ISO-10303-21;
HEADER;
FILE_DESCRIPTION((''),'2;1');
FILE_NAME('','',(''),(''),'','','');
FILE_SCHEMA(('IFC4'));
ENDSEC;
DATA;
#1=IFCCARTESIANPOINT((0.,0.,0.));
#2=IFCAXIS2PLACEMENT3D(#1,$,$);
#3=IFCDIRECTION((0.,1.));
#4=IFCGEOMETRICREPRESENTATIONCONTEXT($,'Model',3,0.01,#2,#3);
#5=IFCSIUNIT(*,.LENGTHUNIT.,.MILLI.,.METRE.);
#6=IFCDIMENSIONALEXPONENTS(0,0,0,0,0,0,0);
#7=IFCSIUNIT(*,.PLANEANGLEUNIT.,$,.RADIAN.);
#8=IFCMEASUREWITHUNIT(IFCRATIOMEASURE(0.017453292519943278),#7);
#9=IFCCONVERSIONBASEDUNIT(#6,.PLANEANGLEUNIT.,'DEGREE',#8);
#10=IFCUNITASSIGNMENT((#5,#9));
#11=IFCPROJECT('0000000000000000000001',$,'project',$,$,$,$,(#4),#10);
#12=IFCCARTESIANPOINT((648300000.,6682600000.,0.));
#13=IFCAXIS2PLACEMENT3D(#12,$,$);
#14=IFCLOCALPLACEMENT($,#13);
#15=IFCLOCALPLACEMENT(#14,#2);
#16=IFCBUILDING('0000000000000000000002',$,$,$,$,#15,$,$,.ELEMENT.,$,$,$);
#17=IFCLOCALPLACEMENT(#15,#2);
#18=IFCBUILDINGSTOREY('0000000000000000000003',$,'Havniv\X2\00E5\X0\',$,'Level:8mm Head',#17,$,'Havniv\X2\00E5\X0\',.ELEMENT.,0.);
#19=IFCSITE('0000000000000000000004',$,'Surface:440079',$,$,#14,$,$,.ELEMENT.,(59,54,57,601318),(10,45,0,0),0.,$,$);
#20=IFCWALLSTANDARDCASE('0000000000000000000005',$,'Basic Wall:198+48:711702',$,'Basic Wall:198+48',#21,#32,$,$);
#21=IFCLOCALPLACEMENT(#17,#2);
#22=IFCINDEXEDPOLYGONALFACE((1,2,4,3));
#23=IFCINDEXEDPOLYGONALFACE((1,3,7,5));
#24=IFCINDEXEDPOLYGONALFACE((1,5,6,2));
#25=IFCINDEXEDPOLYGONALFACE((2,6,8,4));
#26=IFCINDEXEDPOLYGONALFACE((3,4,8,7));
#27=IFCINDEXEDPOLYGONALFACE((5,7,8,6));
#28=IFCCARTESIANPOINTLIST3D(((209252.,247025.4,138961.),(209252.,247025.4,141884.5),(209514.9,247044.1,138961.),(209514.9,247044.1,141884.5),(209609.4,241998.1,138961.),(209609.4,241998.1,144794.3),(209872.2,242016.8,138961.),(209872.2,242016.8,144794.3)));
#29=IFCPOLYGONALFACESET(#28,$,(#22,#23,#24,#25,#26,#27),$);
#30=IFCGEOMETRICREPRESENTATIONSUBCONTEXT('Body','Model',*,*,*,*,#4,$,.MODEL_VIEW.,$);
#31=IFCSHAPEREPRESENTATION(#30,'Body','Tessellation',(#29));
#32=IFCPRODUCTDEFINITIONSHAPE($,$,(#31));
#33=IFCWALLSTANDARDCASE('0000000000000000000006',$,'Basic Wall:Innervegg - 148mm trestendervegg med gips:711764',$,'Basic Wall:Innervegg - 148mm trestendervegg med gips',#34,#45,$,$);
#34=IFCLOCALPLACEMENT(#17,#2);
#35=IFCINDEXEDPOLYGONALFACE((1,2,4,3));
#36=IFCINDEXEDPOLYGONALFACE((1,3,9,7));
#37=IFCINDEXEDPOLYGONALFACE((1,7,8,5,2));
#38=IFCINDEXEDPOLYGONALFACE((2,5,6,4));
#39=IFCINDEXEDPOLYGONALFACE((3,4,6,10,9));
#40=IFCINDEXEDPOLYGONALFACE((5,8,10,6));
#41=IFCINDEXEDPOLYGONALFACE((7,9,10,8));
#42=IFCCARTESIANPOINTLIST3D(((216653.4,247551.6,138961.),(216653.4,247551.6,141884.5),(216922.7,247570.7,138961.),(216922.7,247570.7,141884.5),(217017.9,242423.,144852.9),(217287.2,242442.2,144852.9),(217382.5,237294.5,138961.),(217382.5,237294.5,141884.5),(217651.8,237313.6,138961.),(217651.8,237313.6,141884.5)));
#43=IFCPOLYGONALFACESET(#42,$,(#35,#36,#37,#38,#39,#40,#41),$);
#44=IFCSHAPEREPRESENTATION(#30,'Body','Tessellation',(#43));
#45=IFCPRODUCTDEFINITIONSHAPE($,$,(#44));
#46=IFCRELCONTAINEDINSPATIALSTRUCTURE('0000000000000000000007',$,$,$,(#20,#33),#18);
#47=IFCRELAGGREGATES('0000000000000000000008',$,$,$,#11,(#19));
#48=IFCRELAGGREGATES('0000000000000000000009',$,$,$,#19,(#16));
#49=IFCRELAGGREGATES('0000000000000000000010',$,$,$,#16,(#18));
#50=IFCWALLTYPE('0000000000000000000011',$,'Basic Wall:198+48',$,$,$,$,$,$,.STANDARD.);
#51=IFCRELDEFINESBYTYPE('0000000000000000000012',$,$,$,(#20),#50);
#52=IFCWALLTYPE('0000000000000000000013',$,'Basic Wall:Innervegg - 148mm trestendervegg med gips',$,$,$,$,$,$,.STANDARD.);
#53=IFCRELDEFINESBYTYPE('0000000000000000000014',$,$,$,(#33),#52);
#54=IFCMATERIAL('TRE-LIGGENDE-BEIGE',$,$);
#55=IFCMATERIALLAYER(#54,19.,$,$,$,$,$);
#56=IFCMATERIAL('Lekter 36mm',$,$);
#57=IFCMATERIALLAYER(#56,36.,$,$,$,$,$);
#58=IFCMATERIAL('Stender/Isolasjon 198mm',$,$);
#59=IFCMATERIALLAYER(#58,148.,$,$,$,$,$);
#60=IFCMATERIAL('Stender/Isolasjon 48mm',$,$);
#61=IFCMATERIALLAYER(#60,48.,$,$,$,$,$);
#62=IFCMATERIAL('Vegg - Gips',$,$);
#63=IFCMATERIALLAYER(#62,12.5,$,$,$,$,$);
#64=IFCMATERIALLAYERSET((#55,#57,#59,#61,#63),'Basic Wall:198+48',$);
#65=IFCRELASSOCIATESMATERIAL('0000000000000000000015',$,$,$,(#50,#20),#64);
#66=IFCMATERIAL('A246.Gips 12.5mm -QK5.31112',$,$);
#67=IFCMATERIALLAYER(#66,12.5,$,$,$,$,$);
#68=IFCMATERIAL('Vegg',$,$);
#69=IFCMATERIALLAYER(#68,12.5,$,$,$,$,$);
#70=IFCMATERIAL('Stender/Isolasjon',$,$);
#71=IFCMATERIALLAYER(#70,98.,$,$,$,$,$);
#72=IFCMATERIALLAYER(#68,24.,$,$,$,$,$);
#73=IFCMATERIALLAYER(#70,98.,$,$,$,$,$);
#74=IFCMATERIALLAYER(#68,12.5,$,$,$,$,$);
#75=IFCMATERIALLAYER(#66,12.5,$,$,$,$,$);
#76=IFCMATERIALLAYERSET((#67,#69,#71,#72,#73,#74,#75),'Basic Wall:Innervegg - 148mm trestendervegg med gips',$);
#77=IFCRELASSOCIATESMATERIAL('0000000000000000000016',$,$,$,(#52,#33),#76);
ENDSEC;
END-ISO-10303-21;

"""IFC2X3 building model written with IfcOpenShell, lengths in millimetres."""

from ifc_helpers import new_model, entity, si_unit, converted_unit, direction, frame, frame_2d, origin, place, context, subcontext, project, spatial, polyline, rectangle, extrude, clip, bounded_halfspace, material, layer, layer_set, layer_usage, type_object, element, save


model = new_model("IFC2X3")

# Units and contexts
model_context = context("Model", 3, precision=0.01, world=origin(), true_north=direction((0.0, 1.0)))
body_context = subcontext(model_context, "Body", "Model", "MODEL_VIEW")
ifc_project = project(units=[si_unit("LENGTHUNIT", "METRE", prefix="MILLI"), converted_unit("PLANEANGLEUNIT", "DEGREE", entity("IfcRatioMeasure", 0.017453292519943278), si_unit("PLANEANGLEUNIT", "RADIAN"), dimensions=[0, 0, 0, 0, 0, 0, 0])], contexts=[model_context])

# Site, building, storey
site_placement = place(None, frame((648300000.0, 6682600000.0, 0.0)))
site = spatial("IfcSite", under=ifc_project, at=site_placement, Name="Surface:440079", CompositionType="ELEMENT", RefLatitude=(59, 54, 57, 601318), RefLongitude=(10, 45, 0, 0), RefElevation=0.0)
building_placement = place(site_placement, origin())
building = spatial("IfcBuilding", under=site, at=building_placement, CompositionType="ELEMENT")
storey_placement = place(building_placement, origin())
storey = spatial("IfcBuildingStorey", under=building, at=storey_placement, Name="Havnivå", ObjectType="Level:8mm Head", LongName="Havnivå", CompositionType="ELEMENT", Elevation=0.0)

# Walls
ifc_material_1 = material(Name="TRE-LIGGENDE-BEIGE")
ifc_layer_1 = layer(ifc_material_1, 19.0)
ifc_material_2 = material(Name="Lekter 36mm")
ifc_layer_2 = layer(ifc_material_2, 36.0)
ifc_material_3 = material(Name="Stender/Isolasjon 198mm")
ifc_layer_3 = layer(ifc_material_3, 148.0)
ifc_material_4 = material(Name="Stender/Isolasjon 48mm")
ifc_layer_4 = layer(ifc_material_4, 48.0)
ifc_material_5 = material(Name="Vegg - Gips")
ifc_layer_5 = layer(ifc_material_5, 12.5)
ifc_layer_set_1 = layer_set([ifc_layer_1, ifc_layer_2, ifc_layer_3, ifc_layer_4, ifc_layer_5], Name="Basic Wall:198+48")
ifc_layer_usage_1 = layer_usage(ifc_layer_set_1, "AXIS2", "POSITIVE", -131.8)
wall_type_1 = type_object("IfcWallType", Name="Basic Wall:198+48", PredefinedType="STANDARD", material=ifc_layer_set_1)
wall_1_placement = place(storey_placement, frame((209383.4, 247034.8, 138961.0), z_axis=(0.0, 0.0, 1.0), x_axis=(0.070908, -0.997483, 0.0)))
element("IfcWallStandardCase", 1, at=wall_1_placement, inside=storey, type_object=wall_type_1, material=ifc_layer_usage_1, Name="Basic Wall:198+48:711702", ObjectType="Basic Wall:198+48", context=body_context, shape_type="Clipping", body=[
    clip(extrude(rectangle(XDim=5040.0, YDim=263.5, at=frame_2d((2520.0, 0.0), x_axis=(-1.0, 0.0))), origin(), (0.0, 0.0, 1.0), 5833.3), bounded_halfspace(frame((0.0, -131.8, 2923.5), z_axis=(-0.5, 0.0, 0.866025), x_axis=(0.0, -1.0, 0.0)), False, frame((0.0, -131.8, 2923.5)), polyline([(0.0, 0.0), (1536192.0, 0.0), (1536192.0, 80314.8), (0.0, 80314.8), (0.0, 0.0)]))),
])
ifc_material_6 = material(Name="A246.Gips 12.5mm -QK5.31112")
ifc_layer_6 = layer(ifc_material_6, 12.5)
ifc_material_7 = material(Name="Vegg")
ifc_layer_7 = layer(ifc_material_7, 12.5)
ifc_material_8 = material(Name="Stender/Isolasjon")
ifc_layer_8 = layer(ifc_material_8, 98.0)
ifc_layer_9 = layer(ifc_material_7, 24.0)
ifc_layer_10 = layer(ifc_material_8, 98.0)
ifc_layer_11 = layer(ifc_material_7, 12.5)
ifc_layer_12 = layer(ifc_material_6, 12.5)
ifc_layer_set_2 = layer_set([ifc_layer_6, ifc_layer_7, ifc_layer_8, ifc_layer_9, ifc_layer_10, ifc_layer_11, ifc_layer_12], Name="Basic Wall:Innervegg - 148mm trestendervegg med gips")
ifc_layer_usage_2 = layer_usage(ifc_layer_set_2, "AXIS2", "NEGATIVE", 135.0)
wall_type_2 = type_object("IfcWallType", Name="Basic Wall:Innervegg - 148mm trestendervegg med gips", PredefinedType="STANDARD", material=ifc_layer_set_2)
wall_2_placement = place(storey_placement, frame((216788.0, 247561.1, 138961.0), z_axis=(0.0, 0.0, 1.0), x_axis=(0.070908, -0.997483, 0.0)))
element("IfcWallStandardCase", 2, at=wall_2_placement, inside=storey, type_object=wall_type_2, material=ifc_layer_usage_2, Name="Basic Wall:Innervegg - 148mm trestendervegg med gips:711764", ObjectType="Basic Wall:Innervegg - 148mm trestendervegg med gips", context=body_context, shape_type="Clipping", body=[
    clip(clip(extrude(rectangle(XDim=10283.0, YDim=270.0, at=frame_2d((5141.5, 0.0), x_axis=(-1.0, 0.0))), origin(), (0.0, 0.0, 1.0), 5891.9), bounded_halfspace(frame((5141.5, -135.0, 5891.9), z_axis=(0.5, 0.0, 0.866025), x_axis=(0.0, 1.0, 0.0)), False, frame((5141.5, -135.0, 5891.9)), polyline([(0.0, 0.0), (1567129.2, 0.0), (1567129.2, 82296.0), (0.0, 82296.0), (0.0, 0.0)]))), bounded_halfspace(frame((0.0, -135.0, 2923.5), z_axis=(-0.5, 0.0, 0.866025), x_axis=(0.0, -1.0, 0.0)), False, frame((0.0, -135.0, 2923.5)), polyline([(0.0, 0.0), (1567129.2, 0.0), (1567129.2, 82296.0), (0.0, 82296.0), (0.0, 0.0)]))),
])

save(model, "model.ifc")
